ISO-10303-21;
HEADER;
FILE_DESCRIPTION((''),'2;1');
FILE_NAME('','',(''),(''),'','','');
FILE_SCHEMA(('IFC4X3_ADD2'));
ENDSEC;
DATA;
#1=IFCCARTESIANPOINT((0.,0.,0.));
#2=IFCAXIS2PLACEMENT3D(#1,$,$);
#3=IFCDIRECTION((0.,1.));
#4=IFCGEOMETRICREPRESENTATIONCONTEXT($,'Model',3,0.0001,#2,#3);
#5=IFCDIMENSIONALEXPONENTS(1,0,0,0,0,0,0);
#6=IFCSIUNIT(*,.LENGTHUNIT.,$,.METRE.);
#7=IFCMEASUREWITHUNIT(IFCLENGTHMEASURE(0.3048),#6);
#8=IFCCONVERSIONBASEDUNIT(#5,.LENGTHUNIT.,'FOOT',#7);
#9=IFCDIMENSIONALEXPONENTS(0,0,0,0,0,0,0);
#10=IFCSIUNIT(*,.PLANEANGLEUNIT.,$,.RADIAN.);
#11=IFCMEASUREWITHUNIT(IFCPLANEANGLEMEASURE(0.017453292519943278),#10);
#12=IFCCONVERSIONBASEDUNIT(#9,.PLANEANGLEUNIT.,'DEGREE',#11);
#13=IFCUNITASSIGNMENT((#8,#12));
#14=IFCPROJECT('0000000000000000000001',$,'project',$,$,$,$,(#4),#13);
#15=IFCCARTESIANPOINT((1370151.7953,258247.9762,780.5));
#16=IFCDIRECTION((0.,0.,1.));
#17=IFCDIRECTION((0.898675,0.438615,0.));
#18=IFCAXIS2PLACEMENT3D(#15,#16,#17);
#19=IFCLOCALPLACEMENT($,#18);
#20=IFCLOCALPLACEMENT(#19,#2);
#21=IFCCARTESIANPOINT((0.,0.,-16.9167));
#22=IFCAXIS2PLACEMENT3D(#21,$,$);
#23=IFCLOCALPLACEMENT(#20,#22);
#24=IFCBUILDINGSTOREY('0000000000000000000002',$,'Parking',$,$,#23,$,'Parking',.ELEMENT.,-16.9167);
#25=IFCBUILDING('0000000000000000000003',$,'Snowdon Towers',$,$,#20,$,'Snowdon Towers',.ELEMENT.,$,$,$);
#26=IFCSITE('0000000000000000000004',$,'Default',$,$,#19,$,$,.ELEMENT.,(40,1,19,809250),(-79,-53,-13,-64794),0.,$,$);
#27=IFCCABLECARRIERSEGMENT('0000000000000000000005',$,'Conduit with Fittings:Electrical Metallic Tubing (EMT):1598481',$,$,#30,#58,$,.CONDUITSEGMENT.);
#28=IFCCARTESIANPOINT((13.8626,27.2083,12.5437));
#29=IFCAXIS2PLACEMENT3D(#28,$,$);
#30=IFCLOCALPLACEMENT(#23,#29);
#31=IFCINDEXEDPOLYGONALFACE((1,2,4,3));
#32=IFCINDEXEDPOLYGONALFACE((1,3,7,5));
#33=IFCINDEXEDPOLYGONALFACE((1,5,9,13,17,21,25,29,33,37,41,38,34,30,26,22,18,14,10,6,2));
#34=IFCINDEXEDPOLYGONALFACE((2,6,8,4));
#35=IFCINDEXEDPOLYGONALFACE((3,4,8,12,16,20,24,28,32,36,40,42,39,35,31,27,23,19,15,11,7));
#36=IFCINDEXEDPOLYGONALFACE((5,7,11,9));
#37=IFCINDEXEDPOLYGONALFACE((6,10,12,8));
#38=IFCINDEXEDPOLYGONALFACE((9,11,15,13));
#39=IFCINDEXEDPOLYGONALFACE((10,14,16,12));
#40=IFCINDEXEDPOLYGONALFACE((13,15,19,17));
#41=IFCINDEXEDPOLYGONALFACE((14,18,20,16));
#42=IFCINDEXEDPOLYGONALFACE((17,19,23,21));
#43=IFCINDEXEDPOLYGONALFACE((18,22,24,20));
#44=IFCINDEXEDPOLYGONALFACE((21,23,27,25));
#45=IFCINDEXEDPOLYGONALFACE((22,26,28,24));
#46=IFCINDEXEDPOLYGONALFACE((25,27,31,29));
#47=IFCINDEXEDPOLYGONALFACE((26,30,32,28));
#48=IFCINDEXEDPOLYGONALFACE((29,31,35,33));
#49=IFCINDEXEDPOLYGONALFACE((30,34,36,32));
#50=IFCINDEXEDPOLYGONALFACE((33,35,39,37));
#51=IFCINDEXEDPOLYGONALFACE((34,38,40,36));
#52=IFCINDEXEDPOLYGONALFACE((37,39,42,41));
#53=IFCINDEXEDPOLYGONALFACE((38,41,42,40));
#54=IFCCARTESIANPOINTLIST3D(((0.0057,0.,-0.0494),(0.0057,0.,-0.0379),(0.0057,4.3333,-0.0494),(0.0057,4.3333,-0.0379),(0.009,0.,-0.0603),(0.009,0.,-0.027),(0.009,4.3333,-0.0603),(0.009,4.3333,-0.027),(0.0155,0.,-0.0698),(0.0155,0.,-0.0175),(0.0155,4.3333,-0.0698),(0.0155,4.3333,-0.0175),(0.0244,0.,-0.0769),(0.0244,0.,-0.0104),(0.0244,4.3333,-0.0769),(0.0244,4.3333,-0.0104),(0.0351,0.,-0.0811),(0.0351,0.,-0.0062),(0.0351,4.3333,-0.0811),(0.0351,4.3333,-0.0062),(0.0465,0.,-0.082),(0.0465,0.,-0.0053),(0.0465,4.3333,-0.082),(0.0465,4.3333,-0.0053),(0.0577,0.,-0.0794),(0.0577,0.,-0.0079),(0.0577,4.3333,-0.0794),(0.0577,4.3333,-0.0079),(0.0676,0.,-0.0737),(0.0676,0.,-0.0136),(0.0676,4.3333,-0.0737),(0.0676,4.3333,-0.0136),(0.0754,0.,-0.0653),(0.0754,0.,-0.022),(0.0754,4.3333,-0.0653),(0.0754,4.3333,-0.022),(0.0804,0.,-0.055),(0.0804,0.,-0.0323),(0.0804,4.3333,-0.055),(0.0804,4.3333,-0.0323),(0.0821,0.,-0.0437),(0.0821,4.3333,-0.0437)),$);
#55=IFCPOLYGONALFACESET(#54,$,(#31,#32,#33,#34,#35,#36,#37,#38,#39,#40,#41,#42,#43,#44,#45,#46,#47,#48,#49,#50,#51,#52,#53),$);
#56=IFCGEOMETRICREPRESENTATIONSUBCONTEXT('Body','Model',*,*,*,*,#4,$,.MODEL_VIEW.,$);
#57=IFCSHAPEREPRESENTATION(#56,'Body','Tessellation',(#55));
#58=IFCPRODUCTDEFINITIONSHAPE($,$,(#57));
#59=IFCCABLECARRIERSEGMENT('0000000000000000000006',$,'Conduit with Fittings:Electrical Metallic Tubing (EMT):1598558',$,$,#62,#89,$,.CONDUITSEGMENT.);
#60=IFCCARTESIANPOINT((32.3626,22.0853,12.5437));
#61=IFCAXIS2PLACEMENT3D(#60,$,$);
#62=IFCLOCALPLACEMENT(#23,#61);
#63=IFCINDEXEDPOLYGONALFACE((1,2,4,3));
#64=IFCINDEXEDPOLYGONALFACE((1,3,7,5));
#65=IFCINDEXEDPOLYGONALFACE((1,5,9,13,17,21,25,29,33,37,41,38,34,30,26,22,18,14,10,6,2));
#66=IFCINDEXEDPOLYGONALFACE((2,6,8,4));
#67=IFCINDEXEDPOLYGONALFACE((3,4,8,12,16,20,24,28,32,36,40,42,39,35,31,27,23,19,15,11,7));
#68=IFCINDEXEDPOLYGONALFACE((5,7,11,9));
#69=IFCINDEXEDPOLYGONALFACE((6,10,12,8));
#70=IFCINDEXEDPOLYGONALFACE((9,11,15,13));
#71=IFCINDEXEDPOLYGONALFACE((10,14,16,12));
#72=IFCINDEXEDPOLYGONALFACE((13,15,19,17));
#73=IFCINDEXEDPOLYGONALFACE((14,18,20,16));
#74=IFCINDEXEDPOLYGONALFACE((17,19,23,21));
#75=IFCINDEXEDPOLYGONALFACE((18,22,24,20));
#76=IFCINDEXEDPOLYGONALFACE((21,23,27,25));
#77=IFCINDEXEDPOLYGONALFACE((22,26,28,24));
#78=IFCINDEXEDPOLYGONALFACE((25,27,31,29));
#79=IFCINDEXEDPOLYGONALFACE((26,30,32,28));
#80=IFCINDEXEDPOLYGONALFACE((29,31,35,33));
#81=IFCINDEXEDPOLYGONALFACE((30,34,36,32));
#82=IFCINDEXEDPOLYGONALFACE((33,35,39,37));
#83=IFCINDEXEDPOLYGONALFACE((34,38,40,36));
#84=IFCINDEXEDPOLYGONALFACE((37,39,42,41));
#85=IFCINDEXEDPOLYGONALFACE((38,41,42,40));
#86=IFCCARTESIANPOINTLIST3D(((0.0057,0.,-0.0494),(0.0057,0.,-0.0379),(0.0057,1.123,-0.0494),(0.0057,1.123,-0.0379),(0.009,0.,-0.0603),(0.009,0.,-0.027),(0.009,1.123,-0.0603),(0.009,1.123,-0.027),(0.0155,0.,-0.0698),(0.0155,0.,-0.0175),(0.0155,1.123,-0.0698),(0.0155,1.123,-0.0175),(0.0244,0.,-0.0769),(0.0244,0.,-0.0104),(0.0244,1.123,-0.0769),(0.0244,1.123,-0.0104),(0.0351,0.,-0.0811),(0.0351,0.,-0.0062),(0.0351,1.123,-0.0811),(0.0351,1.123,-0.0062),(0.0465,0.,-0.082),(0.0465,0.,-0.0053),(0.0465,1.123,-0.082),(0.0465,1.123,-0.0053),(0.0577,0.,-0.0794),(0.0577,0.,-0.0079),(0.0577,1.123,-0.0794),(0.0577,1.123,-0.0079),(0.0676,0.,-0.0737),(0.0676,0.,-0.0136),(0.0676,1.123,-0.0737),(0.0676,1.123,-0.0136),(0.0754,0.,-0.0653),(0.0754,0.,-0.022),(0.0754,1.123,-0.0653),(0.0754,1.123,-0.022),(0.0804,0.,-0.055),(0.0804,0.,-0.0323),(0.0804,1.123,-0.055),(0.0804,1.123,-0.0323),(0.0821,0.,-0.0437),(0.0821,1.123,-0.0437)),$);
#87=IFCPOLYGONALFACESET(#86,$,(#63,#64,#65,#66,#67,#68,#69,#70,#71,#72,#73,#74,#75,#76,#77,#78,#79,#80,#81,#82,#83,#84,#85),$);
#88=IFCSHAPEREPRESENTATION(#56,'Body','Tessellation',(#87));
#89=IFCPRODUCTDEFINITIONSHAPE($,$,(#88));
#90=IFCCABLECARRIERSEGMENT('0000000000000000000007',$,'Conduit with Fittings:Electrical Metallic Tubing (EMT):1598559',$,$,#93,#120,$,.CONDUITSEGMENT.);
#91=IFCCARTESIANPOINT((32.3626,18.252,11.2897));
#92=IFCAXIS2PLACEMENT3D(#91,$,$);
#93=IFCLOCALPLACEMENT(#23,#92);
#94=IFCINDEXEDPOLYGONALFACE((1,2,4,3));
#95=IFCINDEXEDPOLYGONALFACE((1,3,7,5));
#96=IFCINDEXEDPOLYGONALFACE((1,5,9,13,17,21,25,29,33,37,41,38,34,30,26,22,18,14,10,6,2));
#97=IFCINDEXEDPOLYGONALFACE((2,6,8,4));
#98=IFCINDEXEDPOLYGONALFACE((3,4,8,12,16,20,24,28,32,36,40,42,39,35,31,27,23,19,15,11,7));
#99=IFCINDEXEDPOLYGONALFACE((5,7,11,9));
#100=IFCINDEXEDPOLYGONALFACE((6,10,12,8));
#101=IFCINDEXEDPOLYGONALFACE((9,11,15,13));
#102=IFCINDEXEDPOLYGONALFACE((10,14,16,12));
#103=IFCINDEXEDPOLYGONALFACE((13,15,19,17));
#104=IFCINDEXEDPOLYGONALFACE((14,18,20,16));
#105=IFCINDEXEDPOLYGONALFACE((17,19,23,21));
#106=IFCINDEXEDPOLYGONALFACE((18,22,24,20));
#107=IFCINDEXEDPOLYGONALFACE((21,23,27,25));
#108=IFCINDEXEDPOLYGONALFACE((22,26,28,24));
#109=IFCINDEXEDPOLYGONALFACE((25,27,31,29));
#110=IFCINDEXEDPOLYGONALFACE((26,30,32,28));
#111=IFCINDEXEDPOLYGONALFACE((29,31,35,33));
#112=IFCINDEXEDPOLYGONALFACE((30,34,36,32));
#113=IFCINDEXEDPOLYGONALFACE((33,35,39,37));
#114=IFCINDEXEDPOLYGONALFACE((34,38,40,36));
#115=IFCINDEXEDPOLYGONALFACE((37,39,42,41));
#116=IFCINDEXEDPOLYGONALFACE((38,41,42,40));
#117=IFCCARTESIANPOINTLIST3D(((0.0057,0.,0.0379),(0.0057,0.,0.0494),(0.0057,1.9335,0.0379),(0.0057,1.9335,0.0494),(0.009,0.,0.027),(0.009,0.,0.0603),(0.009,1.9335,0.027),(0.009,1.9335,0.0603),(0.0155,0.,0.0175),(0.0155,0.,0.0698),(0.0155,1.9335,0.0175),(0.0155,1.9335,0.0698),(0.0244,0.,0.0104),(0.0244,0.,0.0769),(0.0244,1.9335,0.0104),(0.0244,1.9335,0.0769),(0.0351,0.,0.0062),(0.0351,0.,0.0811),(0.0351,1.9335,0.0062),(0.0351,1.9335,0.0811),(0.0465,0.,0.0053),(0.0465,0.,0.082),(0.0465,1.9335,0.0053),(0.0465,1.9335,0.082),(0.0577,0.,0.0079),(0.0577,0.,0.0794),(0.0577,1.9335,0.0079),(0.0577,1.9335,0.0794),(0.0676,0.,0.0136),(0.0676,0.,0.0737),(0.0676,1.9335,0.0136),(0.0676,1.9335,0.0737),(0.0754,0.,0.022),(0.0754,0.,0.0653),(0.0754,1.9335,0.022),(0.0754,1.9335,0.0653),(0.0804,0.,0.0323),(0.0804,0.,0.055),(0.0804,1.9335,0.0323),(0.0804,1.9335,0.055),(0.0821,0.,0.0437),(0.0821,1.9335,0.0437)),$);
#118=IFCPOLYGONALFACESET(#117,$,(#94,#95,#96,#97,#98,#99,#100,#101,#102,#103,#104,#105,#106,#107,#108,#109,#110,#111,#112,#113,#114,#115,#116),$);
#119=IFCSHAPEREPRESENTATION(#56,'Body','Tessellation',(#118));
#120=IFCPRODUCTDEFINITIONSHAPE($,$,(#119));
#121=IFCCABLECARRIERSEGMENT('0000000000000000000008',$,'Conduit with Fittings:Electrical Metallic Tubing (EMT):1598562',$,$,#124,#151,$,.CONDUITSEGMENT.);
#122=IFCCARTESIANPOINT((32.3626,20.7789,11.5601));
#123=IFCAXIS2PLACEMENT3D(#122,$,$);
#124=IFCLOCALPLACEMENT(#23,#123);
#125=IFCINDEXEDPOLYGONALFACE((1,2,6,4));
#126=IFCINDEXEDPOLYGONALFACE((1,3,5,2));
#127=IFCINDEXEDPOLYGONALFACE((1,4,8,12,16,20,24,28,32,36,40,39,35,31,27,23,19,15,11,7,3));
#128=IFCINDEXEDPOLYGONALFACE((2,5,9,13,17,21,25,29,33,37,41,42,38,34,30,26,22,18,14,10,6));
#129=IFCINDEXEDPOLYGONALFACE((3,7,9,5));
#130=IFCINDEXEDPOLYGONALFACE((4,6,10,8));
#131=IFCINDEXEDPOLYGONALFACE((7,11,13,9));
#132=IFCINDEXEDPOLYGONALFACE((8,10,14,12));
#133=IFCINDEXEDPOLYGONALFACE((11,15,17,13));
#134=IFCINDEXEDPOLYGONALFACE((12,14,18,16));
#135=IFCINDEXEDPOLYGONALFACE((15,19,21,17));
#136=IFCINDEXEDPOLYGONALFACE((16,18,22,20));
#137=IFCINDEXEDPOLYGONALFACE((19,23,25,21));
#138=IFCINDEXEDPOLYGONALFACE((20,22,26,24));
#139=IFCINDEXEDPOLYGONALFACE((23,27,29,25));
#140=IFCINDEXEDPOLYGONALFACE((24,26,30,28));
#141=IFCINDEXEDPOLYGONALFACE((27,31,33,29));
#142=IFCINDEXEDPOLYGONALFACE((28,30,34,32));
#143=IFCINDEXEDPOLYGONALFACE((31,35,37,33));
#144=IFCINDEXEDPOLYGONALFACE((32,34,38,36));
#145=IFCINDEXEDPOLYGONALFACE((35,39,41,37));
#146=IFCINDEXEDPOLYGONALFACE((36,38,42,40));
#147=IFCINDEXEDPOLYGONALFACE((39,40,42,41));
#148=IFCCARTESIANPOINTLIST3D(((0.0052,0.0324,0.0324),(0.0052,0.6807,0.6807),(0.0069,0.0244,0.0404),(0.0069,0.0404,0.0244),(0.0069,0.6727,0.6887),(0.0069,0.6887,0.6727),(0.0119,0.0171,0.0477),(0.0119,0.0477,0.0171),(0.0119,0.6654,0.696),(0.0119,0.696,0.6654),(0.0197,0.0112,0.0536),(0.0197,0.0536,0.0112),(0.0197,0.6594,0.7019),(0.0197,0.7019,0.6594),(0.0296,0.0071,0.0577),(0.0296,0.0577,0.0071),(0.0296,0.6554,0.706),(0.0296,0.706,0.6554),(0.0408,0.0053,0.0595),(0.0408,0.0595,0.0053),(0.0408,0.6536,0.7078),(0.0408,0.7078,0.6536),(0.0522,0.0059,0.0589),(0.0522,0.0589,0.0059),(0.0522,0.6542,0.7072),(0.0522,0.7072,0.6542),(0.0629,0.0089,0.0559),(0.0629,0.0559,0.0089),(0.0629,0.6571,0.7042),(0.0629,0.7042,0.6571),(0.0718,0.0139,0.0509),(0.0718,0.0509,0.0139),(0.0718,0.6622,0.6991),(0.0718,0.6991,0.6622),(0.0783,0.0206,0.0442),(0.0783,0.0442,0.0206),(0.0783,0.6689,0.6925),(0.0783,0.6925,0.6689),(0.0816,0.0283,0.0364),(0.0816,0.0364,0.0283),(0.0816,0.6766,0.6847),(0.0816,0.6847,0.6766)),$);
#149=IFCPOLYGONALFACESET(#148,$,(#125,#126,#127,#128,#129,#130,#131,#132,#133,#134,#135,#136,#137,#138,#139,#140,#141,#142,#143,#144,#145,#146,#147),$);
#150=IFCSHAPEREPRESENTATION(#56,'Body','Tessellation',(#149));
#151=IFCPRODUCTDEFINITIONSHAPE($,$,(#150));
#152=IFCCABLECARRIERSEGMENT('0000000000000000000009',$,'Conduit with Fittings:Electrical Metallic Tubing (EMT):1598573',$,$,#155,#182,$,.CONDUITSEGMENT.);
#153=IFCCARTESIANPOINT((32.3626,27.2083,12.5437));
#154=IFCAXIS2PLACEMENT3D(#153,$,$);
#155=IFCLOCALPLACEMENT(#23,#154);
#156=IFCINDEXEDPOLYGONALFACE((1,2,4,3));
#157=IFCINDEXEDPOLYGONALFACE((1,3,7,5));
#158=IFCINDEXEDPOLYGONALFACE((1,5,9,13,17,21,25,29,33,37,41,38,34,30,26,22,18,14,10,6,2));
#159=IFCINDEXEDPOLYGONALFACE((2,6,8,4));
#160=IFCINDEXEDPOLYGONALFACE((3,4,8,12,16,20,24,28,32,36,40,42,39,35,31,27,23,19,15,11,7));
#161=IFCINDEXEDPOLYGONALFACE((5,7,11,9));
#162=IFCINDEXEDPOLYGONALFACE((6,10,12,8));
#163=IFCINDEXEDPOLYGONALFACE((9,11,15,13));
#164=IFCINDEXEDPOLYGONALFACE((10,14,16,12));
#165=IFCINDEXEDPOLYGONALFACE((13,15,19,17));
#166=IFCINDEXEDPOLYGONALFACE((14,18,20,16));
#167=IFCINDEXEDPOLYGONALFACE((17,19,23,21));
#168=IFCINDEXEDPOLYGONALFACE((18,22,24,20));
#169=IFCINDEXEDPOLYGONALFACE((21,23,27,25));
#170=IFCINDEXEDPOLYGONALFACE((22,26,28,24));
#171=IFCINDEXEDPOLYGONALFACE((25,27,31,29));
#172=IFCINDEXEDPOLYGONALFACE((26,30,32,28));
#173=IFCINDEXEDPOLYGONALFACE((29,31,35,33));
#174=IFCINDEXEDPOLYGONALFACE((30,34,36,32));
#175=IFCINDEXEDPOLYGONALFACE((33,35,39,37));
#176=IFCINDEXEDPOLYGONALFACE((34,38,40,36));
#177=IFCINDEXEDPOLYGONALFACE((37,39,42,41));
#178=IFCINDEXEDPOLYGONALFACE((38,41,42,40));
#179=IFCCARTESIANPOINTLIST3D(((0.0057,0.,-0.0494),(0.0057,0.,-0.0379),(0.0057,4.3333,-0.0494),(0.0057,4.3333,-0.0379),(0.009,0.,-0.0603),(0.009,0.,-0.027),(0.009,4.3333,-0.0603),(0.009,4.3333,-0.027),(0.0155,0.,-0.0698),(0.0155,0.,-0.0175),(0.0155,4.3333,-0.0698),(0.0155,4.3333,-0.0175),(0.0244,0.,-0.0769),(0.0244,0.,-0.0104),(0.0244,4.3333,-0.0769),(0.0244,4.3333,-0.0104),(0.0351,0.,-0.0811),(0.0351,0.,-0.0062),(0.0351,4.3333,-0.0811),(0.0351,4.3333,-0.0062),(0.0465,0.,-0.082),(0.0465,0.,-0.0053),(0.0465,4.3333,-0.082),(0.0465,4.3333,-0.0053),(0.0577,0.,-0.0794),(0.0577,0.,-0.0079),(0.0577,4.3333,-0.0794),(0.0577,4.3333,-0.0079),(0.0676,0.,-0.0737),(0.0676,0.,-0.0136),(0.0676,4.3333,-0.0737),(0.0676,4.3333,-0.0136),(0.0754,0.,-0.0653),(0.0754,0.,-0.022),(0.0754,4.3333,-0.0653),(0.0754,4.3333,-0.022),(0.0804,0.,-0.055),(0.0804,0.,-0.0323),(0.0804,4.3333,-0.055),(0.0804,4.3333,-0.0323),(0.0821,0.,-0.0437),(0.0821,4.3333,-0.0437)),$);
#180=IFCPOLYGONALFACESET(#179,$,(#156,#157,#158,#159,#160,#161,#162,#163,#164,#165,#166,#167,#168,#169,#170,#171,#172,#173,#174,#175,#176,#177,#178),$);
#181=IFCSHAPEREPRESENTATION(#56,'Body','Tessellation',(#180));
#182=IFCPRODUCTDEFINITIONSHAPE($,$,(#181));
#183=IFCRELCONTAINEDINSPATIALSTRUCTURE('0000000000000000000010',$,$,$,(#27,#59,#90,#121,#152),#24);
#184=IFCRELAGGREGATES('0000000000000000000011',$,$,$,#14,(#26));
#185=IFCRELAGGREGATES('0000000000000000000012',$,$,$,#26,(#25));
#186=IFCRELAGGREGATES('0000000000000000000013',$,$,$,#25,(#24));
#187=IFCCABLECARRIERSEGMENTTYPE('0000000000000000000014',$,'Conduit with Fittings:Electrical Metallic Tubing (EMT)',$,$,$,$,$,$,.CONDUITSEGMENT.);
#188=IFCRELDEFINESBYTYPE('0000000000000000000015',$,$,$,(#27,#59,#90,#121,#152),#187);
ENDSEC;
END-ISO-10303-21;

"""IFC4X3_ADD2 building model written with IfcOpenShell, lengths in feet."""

from ifc_helpers import new_model, entity, si_unit, converted_unit, direction, frame, origin, origin_2d_with_axis, place, context, subcontext, project, spatial, circle, extrude, type_object, element, save


model = new_model("IFC4X3_ADD2")

# Units and contexts
model_context = context("Model", 3, precision=0.0001, world=origin(), true_north=direction((0.0, 1.0)))
body_context = subcontext(model_context, "Body", "Model", "MODEL_VIEW")
ifc_project = project(units=[converted_unit("LENGTHUNIT", "FOOT", entity("IfcLengthMeasure", 0.3048), si_unit("LENGTHUNIT", "METRE"), dimensions=[1, 0, 0, 0, 0, 0, 0]), converted_unit("PLANEANGLEUNIT", "DEGREE", entity("IfcPlaneAngleMeasure", 0.017453292519943278), si_unit("PLANEANGLEUNIT", "RADIAN"), dimensions=[0, 0, 0, 0, 0, 0, 0])], contexts=[model_context])

# Site, building, storey
site_placement = place(None, frame((1370151.7953, 258247.9762, 780.5), z_axis=(0.0, 0.0, 1.0), x_axis=(0.898675, 0.438615, 0.0)))
site = spatial("IfcSite", under=ifc_project, at=site_placement, Name="Default", CompositionType="ELEMENT", RefLatitude=(40, 1, 19, 809250), RefLongitude=(-79, -53, -13, -64794), RefElevation=0.0)
building_placement = place(site_placement, origin())
building = spatial("IfcBuilding", under=site, at=building_placement, Name="Snowdon Towers", LongName="Snowdon Towers", CompositionType="ELEMENT")
storey_placement = place(building_placement, frame((0.0, 0.0, -16.9167)))
storey = spatial("IfcBuildingStorey", under=building, at=storey_placement, Name="Parking", LongName="Parking", CompositionType="ELEMENT", Elevation=-16.9167)

# Cable carrier segments
cable_carrier_segment_type_1 = type_object("IfcCableCarrierSegmentType", Name="Conduit with Fittings:Electrical Metallic Tubing (EMT)", PredefinedType="CONDUITSEGMENT")
cable_carrier_segment_1_placement = place(storey_placement, frame((13.8626, 27.2083, 12.5437)))
element("IfcCableCarrierSegment", 1, at=cable_carrier_segment_1_placement, inside=storey, type_object=cable_carrier_segment_type_1, Name="Conduit with Fittings:Electrical Metallic Tubing (EMT):1598481", PredefinedType="CONDUITSEGMENT", context=body_context, shape_type="SweptSolid", body=[
    extrude(circle(Radius=0.0384, at=origin_2d_with_axis()), frame((0.0437, 0.0, -0.0437), z_axis=(0.0, 1.0, 0.0), x_axis=(1.0, 0.0, 0.0)), (0.0, 0.0, 1.0), 4.3333),
])
cable_carrier_segment_2_placement = place(storey_placement, frame((32.3626, 22.0853, 12.5437)))
element("IfcCableCarrierSegment", 2, at=cable_carrier_segment_2_placement, inside=storey, type_object=cable_carrier_segment_type_1, Name="Conduit with Fittings:Electrical Metallic Tubing (EMT):1598558", PredefinedType="CONDUITSEGMENT", context=body_context, shape_type="SweptSolid", body=[
    extrude(circle(Radius=0.0384, at=origin_2d_with_axis()), frame((0.0437, 0.0, -0.0437), z_axis=(0.0, 1.0, 0.0), x_axis=(1.0, 0.0, 0.0)), (0.0, 0.0, 1.0), 1.123),
])
cable_carrier_segment_3_placement = place(storey_placement, frame((32.3626, 18.252, 11.2897)))
element("IfcCableCarrierSegment", 3, at=cable_carrier_segment_3_placement, inside=storey, type_object=cable_carrier_segment_type_1, Name="Conduit with Fittings:Electrical Metallic Tubing (EMT):1598559", PredefinedType="CONDUITSEGMENT", context=body_context, shape_type="SweptSolid", body=[
    extrude(circle(Radius=0.0384, at=origin_2d_with_axis()), frame((0.0437, 0.0, 0.0437), z_axis=(0.0, 1.0, 0.0), x_axis=(1.0, 0.0, 0.0)), (0.0, 0.0, 1.0), 1.9335),
])
cable_carrier_segment_4_placement = place(storey_placement, frame((32.3626, 20.7789, 11.5601)))
element("IfcCableCarrierSegment", 4, at=cable_carrier_segment_4_placement, inside=storey, type_object=cable_carrier_segment_type_1, Name="Conduit with Fittings:Electrical Metallic Tubing (EMT):1598562", PredefinedType="CONDUITSEGMENT", context=body_context, shape_type="SweptSolid", body=[
    extrude(circle(Radius=0.0384, at=origin_2d_with_axis()), frame((0.0437, 0.0324, 0.0324), z_axis=(0.0, 0.707107, 0.707107), x_axis=(-1.0, 0.0, 0.0)), (0.0, 0.0, 1.0), 0.9168),
])
cable_carrier_segment_5_placement = place(storey_placement, frame((32.3626, 27.2083, 12.5437)))
element("IfcCableCarrierSegment", 5, at=cable_carrier_segment_5_placement, inside=storey, type_object=cable_carrier_segment_type_1, Name="Conduit with Fittings:Electrical Metallic Tubing (EMT):1598573", PredefinedType="CONDUITSEGMENT", context=body_context, shape_type="SweptSolid", body=[
    extrude(circle(Radius=0.0384, at=origin_2d_with_axis()), frame((0.0437, 0.0, -0.0437), z_axis=(0.0, 1.0, 0.0), x_axis=(1.0, 0.0, 0.0)), (0.0, 0.0, 1.0), 4.3333),
])

save(model, "model.ifc")
